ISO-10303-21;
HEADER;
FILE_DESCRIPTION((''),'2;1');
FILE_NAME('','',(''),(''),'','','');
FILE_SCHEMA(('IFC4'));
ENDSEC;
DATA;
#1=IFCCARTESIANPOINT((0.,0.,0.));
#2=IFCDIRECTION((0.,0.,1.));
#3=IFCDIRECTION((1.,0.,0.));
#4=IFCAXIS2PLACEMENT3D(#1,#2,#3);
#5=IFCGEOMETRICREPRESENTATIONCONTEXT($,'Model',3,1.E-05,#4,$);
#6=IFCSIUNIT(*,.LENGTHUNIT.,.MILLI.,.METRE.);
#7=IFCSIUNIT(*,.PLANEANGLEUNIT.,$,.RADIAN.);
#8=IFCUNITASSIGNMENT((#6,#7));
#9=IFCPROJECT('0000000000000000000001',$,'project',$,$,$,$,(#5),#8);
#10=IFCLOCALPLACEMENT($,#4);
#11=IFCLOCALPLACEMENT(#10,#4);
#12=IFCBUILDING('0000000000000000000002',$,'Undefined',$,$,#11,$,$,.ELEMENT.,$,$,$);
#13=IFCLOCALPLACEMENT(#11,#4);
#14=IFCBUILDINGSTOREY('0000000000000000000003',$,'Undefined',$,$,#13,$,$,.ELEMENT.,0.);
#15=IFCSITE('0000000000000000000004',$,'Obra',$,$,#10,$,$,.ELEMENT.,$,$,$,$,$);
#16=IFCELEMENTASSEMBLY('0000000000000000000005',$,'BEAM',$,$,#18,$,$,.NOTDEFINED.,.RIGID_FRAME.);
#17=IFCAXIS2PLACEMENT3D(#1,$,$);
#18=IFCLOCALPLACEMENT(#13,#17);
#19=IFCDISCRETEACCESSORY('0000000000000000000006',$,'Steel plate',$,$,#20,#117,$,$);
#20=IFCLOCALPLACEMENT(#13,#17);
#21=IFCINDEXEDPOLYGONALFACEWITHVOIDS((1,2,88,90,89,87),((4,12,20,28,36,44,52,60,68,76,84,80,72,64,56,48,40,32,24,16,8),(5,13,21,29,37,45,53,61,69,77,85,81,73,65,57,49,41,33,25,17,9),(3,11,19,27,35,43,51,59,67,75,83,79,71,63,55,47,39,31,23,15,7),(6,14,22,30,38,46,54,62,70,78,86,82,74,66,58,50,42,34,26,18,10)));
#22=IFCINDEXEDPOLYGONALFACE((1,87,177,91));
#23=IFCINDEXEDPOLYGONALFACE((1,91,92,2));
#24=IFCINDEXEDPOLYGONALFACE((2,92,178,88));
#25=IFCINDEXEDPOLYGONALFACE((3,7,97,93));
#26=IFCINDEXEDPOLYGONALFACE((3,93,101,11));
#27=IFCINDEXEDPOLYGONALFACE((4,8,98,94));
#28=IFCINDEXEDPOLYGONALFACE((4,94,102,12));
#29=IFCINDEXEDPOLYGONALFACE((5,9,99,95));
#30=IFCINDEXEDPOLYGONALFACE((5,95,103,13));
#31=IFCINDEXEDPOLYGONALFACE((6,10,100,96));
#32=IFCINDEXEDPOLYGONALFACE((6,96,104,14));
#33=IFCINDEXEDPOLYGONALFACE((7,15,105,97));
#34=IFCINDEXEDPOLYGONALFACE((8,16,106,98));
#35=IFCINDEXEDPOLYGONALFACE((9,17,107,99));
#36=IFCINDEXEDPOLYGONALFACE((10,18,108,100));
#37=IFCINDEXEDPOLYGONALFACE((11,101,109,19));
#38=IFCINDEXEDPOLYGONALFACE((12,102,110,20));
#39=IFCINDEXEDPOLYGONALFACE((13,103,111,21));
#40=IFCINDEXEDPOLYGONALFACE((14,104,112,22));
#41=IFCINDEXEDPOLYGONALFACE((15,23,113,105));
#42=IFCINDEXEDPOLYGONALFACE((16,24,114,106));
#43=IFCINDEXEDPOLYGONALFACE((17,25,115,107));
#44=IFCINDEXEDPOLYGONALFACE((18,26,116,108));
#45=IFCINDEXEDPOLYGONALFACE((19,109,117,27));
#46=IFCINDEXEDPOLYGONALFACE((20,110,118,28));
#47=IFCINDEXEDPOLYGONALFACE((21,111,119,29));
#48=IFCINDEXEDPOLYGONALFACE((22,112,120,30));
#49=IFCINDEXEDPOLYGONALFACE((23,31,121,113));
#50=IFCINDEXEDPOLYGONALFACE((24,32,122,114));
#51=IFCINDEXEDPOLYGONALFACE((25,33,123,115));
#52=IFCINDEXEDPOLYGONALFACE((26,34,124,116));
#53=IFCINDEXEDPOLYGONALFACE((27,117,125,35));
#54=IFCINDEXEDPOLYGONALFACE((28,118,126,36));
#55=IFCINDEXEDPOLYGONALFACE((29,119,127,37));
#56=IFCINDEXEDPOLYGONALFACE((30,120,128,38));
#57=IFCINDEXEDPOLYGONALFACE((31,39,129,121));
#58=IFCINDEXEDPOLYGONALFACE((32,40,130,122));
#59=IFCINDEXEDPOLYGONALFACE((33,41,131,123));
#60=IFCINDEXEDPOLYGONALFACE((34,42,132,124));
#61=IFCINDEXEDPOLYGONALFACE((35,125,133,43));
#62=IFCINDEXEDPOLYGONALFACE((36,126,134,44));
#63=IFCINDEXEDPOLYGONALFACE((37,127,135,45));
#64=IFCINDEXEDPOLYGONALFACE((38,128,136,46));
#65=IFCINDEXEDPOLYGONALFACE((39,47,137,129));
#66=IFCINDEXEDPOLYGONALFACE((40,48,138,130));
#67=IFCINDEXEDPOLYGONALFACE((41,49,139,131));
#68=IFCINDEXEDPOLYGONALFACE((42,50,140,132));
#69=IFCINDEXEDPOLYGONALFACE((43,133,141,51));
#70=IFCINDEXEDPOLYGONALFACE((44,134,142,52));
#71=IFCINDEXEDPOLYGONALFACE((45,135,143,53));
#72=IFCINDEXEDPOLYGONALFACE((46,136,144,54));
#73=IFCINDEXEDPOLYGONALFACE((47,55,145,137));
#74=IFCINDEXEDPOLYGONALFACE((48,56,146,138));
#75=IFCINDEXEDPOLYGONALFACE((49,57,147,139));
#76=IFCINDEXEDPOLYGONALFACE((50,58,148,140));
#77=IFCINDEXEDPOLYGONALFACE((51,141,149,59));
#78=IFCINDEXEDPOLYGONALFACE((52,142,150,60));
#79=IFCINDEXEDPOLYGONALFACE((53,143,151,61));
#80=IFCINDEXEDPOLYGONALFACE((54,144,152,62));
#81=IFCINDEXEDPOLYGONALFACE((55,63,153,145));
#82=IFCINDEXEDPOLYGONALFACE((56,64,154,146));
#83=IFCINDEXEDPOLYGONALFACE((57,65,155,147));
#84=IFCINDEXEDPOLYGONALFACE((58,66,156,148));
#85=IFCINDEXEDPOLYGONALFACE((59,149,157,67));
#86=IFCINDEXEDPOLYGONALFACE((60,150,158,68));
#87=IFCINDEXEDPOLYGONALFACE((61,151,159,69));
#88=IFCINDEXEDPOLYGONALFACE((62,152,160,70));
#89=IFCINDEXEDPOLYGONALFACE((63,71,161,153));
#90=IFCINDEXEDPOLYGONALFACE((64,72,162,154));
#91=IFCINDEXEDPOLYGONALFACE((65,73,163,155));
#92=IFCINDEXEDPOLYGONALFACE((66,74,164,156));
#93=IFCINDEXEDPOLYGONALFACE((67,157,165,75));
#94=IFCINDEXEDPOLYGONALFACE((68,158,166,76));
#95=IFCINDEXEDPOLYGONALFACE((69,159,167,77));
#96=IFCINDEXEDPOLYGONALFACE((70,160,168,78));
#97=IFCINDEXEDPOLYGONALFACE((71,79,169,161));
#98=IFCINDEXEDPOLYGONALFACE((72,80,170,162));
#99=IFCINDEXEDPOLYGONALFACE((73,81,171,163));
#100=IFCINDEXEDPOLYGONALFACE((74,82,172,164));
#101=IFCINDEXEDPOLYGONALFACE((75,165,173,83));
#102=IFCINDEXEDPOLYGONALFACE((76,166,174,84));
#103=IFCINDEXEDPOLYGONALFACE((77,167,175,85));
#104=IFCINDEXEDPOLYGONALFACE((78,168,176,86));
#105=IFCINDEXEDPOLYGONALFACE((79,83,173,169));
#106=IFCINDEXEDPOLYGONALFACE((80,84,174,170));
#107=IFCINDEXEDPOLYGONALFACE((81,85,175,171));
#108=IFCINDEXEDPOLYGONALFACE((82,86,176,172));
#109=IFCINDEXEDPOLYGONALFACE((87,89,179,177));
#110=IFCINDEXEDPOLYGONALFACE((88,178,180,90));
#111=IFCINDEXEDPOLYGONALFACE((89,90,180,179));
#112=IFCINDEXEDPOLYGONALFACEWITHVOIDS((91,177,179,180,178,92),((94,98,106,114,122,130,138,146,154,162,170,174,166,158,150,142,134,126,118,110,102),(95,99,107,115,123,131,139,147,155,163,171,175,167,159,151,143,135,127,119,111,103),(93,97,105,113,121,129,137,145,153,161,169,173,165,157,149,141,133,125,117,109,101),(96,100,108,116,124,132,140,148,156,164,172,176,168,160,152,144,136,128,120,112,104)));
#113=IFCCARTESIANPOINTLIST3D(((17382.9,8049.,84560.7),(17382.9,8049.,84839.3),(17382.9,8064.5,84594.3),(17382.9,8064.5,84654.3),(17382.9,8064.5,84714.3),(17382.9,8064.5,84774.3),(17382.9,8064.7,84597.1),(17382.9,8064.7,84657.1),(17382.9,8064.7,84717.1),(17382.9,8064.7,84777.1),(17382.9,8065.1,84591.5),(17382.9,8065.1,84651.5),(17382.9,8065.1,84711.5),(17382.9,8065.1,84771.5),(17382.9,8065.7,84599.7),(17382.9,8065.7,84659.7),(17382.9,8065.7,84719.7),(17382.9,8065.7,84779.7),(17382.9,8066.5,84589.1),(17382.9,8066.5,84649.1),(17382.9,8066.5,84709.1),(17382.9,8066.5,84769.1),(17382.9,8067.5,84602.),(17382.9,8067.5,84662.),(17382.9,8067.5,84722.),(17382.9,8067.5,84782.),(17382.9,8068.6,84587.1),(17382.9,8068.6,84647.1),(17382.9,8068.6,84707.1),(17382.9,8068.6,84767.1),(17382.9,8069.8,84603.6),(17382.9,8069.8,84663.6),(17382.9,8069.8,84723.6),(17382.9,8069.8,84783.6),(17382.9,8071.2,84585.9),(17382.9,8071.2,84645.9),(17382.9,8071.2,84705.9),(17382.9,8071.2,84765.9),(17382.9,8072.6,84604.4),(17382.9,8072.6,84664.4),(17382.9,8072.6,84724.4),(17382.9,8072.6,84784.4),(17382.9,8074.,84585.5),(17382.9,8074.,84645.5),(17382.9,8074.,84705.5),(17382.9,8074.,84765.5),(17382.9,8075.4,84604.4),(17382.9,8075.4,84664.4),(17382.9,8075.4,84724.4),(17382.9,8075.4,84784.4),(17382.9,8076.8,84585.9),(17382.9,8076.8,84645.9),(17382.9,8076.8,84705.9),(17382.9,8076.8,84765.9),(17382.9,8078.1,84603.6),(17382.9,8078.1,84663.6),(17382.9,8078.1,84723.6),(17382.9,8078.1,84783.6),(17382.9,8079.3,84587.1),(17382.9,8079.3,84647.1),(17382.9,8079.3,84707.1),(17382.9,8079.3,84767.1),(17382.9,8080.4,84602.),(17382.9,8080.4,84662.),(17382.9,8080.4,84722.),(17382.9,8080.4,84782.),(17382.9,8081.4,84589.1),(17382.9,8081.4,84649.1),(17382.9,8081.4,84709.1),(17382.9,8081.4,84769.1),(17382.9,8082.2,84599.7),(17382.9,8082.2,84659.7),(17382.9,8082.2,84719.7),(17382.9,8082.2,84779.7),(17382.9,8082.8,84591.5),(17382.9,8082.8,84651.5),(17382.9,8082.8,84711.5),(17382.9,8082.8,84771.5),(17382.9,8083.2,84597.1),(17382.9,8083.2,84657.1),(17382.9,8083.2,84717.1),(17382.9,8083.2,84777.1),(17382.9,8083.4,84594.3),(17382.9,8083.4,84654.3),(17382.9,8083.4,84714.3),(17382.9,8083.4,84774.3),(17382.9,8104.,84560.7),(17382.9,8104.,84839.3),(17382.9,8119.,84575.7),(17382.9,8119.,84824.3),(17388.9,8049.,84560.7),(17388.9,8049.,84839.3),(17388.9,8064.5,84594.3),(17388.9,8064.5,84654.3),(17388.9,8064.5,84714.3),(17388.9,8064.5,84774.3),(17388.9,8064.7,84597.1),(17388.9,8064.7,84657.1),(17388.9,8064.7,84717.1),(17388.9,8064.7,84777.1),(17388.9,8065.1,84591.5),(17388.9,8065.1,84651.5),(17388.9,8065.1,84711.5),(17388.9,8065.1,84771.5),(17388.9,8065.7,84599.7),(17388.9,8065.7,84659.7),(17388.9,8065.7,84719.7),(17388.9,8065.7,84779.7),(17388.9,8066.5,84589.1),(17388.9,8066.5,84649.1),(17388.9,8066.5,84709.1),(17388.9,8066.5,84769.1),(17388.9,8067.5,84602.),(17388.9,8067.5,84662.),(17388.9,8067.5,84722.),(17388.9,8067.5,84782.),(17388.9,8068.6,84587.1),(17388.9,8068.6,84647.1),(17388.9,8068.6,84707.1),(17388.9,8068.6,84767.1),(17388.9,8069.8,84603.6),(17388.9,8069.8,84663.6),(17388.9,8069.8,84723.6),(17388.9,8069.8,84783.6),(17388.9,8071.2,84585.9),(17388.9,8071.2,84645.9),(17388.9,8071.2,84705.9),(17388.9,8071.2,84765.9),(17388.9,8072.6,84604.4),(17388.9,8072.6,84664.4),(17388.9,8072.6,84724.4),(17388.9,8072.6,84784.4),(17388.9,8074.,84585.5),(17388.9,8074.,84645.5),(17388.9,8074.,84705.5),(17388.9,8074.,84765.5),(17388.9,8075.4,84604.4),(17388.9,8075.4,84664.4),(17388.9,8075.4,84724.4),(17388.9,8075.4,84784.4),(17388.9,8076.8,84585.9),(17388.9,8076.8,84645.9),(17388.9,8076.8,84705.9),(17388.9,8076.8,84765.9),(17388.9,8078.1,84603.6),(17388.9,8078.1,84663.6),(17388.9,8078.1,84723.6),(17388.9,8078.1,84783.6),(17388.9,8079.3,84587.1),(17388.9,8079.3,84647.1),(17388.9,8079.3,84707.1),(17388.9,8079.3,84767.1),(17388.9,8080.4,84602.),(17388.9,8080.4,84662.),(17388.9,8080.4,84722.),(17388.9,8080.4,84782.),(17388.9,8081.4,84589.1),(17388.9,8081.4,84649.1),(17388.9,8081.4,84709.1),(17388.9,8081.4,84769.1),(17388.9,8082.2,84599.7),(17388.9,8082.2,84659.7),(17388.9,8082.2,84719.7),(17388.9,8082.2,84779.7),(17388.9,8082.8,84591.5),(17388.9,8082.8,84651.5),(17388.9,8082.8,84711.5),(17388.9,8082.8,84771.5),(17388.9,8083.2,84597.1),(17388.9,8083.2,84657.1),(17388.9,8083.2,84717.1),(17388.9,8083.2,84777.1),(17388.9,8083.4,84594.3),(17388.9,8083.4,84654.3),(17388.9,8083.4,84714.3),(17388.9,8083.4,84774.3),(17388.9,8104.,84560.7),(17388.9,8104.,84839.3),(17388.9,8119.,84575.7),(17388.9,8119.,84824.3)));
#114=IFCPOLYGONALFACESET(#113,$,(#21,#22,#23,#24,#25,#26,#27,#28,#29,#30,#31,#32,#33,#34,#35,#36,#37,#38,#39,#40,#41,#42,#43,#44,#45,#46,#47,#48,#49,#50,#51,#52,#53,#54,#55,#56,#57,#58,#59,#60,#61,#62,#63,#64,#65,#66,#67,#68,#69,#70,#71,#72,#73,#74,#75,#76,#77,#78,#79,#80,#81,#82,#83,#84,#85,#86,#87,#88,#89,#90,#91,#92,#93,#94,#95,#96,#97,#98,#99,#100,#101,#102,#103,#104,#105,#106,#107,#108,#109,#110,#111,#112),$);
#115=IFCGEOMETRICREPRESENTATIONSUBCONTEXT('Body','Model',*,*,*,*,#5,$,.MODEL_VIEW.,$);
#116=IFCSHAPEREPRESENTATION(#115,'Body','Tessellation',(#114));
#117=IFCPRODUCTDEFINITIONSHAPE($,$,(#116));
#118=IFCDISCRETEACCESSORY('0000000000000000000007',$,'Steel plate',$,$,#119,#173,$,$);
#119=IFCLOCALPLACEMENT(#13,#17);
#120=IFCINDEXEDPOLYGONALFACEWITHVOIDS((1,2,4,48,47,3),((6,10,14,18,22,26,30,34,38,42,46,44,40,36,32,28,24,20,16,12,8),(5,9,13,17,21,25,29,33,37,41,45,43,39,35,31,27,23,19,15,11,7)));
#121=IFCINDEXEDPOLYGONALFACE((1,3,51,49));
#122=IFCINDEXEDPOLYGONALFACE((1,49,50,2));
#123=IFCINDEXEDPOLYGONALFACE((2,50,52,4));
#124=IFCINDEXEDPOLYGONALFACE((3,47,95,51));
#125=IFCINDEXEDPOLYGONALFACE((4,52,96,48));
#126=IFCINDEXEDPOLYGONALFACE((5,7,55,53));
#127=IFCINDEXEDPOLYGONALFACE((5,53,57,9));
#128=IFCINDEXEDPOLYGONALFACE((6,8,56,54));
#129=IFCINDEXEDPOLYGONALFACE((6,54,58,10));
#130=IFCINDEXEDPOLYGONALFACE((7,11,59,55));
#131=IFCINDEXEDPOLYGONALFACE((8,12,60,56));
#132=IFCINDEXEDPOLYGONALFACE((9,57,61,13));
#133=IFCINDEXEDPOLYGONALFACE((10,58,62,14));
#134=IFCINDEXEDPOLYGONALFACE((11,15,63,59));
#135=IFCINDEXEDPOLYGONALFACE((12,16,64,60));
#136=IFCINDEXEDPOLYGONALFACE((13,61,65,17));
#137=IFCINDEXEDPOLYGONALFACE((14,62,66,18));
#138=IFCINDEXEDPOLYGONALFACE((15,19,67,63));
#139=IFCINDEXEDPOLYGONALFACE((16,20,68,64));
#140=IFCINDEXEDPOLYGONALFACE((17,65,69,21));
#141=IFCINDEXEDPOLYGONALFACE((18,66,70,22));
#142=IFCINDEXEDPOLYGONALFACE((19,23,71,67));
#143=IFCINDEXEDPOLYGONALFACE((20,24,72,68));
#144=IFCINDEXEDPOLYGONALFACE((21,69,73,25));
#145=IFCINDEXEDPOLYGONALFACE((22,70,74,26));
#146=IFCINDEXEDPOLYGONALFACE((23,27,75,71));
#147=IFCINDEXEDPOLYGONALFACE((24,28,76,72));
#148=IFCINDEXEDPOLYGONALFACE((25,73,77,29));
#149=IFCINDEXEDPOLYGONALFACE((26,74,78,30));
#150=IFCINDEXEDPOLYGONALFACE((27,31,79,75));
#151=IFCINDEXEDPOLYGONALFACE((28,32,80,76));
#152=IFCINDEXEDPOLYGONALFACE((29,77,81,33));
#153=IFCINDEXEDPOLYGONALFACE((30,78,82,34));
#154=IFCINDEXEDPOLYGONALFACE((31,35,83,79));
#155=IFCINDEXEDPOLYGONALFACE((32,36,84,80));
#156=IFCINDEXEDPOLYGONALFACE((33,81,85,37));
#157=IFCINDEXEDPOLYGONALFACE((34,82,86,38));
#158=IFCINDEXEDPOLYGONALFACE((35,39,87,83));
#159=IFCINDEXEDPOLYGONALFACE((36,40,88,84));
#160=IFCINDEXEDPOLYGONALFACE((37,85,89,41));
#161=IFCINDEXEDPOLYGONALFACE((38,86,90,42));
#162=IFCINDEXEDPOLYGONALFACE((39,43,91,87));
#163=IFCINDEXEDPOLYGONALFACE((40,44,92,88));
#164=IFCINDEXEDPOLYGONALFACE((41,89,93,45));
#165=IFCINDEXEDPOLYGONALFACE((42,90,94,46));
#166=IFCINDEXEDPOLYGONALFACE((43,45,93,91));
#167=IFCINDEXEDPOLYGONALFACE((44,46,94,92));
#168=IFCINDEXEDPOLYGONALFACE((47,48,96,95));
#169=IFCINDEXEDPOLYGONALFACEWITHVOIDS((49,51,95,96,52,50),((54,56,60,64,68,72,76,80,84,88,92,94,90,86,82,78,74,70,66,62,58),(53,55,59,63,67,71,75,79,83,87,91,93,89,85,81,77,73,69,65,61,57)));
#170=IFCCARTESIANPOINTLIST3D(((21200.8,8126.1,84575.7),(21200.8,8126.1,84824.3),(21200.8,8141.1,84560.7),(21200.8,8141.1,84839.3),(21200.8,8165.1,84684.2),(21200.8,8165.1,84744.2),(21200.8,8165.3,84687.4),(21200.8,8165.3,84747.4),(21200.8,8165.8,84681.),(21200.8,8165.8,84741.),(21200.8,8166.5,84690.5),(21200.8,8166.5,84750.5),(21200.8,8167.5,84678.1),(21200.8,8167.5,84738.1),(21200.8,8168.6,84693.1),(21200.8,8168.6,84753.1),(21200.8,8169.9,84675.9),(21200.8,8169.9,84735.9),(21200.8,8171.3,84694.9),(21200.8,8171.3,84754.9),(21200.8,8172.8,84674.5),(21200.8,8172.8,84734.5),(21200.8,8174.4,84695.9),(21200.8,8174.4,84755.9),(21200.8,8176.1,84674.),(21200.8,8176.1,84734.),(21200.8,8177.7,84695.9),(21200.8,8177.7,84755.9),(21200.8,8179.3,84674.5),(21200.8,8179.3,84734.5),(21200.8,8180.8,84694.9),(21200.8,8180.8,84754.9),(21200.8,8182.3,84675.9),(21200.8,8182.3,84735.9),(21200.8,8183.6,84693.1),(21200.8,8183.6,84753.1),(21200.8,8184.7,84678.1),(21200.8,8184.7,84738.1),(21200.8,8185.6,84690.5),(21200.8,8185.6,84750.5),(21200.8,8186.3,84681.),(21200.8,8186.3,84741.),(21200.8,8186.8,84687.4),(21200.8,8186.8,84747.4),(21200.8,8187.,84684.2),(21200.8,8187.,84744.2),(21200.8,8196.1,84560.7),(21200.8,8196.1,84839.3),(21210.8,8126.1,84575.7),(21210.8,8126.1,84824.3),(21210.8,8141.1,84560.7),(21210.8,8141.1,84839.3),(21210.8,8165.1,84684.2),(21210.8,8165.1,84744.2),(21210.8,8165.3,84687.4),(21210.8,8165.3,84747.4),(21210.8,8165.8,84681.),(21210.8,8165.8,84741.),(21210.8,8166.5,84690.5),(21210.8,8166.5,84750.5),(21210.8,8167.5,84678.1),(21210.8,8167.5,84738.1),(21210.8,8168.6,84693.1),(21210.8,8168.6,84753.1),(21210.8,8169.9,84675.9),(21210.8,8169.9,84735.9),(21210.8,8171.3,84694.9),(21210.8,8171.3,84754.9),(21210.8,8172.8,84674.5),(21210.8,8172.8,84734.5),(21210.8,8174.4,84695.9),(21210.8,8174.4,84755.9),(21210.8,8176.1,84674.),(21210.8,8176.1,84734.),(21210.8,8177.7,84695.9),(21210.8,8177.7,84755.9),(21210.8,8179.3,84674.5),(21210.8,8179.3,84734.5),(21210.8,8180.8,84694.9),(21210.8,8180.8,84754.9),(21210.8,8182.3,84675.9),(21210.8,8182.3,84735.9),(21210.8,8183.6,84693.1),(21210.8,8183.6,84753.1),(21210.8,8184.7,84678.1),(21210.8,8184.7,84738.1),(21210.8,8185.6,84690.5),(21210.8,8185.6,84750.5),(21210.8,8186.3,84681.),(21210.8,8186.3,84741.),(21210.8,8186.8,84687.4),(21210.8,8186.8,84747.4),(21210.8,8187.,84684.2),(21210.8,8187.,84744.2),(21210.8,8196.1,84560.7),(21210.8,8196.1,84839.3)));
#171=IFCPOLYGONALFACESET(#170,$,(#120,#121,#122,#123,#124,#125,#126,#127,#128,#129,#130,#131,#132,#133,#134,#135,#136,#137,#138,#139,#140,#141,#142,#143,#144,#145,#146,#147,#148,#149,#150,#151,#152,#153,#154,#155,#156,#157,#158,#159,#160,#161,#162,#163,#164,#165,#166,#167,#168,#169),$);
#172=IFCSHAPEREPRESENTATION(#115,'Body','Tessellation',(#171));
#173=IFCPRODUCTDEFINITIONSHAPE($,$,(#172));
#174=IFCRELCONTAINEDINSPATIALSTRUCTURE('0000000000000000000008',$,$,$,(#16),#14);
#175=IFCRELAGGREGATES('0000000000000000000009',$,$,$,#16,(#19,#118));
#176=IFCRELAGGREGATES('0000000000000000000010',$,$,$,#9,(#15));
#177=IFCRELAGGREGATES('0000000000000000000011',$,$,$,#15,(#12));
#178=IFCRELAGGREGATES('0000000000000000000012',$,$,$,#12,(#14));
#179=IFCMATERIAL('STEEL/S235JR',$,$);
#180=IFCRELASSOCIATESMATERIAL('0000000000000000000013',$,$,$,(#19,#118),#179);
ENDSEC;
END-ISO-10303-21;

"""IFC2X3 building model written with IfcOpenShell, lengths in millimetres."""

from ifc_helpers import new_model, si_unit, frame, origin_with_axes, origin_2d_with_axis, place, context, subcontext, project, spatial, polyline, circle, outline, extrude, source, transform, mapped, material, element, aggregate, save


model = new_model("IFC2X3")

# Units and contexts
model_context = context("Model", 3, precision=1e-05, world=origin_with_axes())
body_context = subcontext(model_context, "Body", "Model", "MODEL_VIEW")
ifc_project = project(units=[si_unit("LENGTHUNIT", "METRE", prefix="MILLI"), si_unit("PLANEANGLEUNIT", "RADIAN")], contexts=[model_context])

# Site, building, storey
site_placement = place(None, origin_with_axes())
site = spatial("IfcSite", under=ifc_project, at=site_placement, Name="Obra", CompositionType="ELEMENT")
building_placement = place(site_placement, origin_with_axes())
building = spatial("IfcBuilding", under=site, at=building_placement, Name="Undefined", CompositionType="ELEMENT")
storey_placement = place(building_placement, origin_with_axes())
storey = spatial("IfcBuildingStorey", under=building, at=storey_placement, Name="Undefined", CompositionType="ELEMENT", Elevation=0.0)

# Shared definitions
ifc_material_1 = material(Name="STEEL/S235JR")

# Element assembly, discrete accessories, openings
assembly_1_placement = place(storey_placement, origin_with_axes())
assembly_1 = element("IfcElementAssembly", 1, at=assembly_1_placement, inside=storey, Name="BEAM", AssemblyPlace="NOTDEFINED", PredefinedType="RIGID_FRAME")
shared_shape_1 = source(origin_with_axes(), body_context, "Body", "SweptSolid", [
    extrude(circle(Radius=9.5, at=origin_2d_with_axis()), frame((0.0, -9.8, 0.0), z_axis=(0.0, 1.0, 0.0), x_axis=(1.0, 0.0, 0.0)), (0.0, 0.0, 1.0), 6.2),
])
discrete_accessory_1_placement = place(assembly_1_placement, frame((17385.9, 8049.0, 84560.7), z_axis=(1.0, 0.0, 0.0), x_axis=(0.0, 1.0, 0.0)))
discrete_accessory_1 = element("IfcDiscreteAccessory", 2, at=discrete_accessory_1_placement, material=ifc_material_1, Name="Steel plate", context=body_context, shape_type="SweptSolid", body=[
    extrude(outline(polyline([(0.0, 0.0), (55.0, 0.0), (70.0, 15.0), (70.0, 263.6), (55.0, 278.6), (0.0, 278.6), (0.0, 0.0)])), frame((0.0, 0.0, -3.0), z_axis=(0.0, 0.0, 1.0), x_axis=(1.0, 0.0, 0.0)), (0.0, 0.0, 1.0), 6.0),
])
opening_1_placement = place(assembly_1_placement, frame((17392.7, 8109.0, 84850.0), z_axis=(0.0, -1.0, 0.0), x_axis=(0.0, 0.0, -1.0)))
element("IfcOpeningElement", 3, at=opening_1_placement, cuts=discrete_accessory_1, ObjectType="Opening", context=body_context, shape_type="MappedRepresentation", body=[
    mapped(shared_shape_1, transform((75.0, 0.0, 35.0))),
    mapped(shared_shape_1, transform((135.0, 0.0, 35.0))),
    mapped(shared_shape_1, transform((195.0, 0.0, 35.0))),
    mapped(shared_shape_1, transform((255.0, 0.0, 35.0))),
])
discrete_accessory_2_placement = place(assembly_1_placement, frame((21205.8, 8196.1, 84560.7), z_axis=(-1.0, 0.0, 0.0), x_axis=(0.0, -1.0, 0.0)))
discrete_accessory_2 = element("IfcDiscreteAccessory", 4, at=discrete_accessory_2_placement, material=ifc_material_1, Name="Steel plate", context=body_context, shape_type="SweptSolid", body=[
    extrude(outline(polyline([(0.0, 0.0), (55.0, 0.0), (70.0, 15.0), (70.0, 263.6), (55.0, 278.6), (0.0, 278.6), (0.0, 0.0)])), frame((0.0, 0.0, -5.0), z_axis=(0.0, 0.0, 1.0), x_axis=(1.0, 0.0, 0.0)), (0.0, 0.0, 1.0), 10.0),
])
shared_shape_2 = source(origin_with_axes(), body_context, "Body", "SweptSolid", [
    extrude(circle(Radius=11.0, at=origin_2d_with_axis()), frame((0.0, -13.4, 0.0), z_axis=(0.0, 1.0, 0.0), x_axis=(1.0, 0.0, 0.0)), (0.0, 0.0, 1.0), 10.2),
])
opening_2_placement = place(assembly_1_placement, frame((21197.5, 8136.1, 84850.0), z_axis=(0.0, 1.0, 0.0), x_axis=(0.0, 0.0, -1.0)))
element("IfcOpeningElement", 5, at=opening_2_placement, cuts=discrete_accessory_2, ObjectType="Opening", context=body_context, shape_type="MappedRepresentation", body=[
    mapped(shared_shape_2, transform((105.0, 0.0, 40.0))),
    mapped(shared_shape_2, transform((165.0, 0.0, 40.0))),
])
aggregate(assembly_1, [discrete_accessory_1, discrete_accessory_2])

save(model, "model.ifc")
